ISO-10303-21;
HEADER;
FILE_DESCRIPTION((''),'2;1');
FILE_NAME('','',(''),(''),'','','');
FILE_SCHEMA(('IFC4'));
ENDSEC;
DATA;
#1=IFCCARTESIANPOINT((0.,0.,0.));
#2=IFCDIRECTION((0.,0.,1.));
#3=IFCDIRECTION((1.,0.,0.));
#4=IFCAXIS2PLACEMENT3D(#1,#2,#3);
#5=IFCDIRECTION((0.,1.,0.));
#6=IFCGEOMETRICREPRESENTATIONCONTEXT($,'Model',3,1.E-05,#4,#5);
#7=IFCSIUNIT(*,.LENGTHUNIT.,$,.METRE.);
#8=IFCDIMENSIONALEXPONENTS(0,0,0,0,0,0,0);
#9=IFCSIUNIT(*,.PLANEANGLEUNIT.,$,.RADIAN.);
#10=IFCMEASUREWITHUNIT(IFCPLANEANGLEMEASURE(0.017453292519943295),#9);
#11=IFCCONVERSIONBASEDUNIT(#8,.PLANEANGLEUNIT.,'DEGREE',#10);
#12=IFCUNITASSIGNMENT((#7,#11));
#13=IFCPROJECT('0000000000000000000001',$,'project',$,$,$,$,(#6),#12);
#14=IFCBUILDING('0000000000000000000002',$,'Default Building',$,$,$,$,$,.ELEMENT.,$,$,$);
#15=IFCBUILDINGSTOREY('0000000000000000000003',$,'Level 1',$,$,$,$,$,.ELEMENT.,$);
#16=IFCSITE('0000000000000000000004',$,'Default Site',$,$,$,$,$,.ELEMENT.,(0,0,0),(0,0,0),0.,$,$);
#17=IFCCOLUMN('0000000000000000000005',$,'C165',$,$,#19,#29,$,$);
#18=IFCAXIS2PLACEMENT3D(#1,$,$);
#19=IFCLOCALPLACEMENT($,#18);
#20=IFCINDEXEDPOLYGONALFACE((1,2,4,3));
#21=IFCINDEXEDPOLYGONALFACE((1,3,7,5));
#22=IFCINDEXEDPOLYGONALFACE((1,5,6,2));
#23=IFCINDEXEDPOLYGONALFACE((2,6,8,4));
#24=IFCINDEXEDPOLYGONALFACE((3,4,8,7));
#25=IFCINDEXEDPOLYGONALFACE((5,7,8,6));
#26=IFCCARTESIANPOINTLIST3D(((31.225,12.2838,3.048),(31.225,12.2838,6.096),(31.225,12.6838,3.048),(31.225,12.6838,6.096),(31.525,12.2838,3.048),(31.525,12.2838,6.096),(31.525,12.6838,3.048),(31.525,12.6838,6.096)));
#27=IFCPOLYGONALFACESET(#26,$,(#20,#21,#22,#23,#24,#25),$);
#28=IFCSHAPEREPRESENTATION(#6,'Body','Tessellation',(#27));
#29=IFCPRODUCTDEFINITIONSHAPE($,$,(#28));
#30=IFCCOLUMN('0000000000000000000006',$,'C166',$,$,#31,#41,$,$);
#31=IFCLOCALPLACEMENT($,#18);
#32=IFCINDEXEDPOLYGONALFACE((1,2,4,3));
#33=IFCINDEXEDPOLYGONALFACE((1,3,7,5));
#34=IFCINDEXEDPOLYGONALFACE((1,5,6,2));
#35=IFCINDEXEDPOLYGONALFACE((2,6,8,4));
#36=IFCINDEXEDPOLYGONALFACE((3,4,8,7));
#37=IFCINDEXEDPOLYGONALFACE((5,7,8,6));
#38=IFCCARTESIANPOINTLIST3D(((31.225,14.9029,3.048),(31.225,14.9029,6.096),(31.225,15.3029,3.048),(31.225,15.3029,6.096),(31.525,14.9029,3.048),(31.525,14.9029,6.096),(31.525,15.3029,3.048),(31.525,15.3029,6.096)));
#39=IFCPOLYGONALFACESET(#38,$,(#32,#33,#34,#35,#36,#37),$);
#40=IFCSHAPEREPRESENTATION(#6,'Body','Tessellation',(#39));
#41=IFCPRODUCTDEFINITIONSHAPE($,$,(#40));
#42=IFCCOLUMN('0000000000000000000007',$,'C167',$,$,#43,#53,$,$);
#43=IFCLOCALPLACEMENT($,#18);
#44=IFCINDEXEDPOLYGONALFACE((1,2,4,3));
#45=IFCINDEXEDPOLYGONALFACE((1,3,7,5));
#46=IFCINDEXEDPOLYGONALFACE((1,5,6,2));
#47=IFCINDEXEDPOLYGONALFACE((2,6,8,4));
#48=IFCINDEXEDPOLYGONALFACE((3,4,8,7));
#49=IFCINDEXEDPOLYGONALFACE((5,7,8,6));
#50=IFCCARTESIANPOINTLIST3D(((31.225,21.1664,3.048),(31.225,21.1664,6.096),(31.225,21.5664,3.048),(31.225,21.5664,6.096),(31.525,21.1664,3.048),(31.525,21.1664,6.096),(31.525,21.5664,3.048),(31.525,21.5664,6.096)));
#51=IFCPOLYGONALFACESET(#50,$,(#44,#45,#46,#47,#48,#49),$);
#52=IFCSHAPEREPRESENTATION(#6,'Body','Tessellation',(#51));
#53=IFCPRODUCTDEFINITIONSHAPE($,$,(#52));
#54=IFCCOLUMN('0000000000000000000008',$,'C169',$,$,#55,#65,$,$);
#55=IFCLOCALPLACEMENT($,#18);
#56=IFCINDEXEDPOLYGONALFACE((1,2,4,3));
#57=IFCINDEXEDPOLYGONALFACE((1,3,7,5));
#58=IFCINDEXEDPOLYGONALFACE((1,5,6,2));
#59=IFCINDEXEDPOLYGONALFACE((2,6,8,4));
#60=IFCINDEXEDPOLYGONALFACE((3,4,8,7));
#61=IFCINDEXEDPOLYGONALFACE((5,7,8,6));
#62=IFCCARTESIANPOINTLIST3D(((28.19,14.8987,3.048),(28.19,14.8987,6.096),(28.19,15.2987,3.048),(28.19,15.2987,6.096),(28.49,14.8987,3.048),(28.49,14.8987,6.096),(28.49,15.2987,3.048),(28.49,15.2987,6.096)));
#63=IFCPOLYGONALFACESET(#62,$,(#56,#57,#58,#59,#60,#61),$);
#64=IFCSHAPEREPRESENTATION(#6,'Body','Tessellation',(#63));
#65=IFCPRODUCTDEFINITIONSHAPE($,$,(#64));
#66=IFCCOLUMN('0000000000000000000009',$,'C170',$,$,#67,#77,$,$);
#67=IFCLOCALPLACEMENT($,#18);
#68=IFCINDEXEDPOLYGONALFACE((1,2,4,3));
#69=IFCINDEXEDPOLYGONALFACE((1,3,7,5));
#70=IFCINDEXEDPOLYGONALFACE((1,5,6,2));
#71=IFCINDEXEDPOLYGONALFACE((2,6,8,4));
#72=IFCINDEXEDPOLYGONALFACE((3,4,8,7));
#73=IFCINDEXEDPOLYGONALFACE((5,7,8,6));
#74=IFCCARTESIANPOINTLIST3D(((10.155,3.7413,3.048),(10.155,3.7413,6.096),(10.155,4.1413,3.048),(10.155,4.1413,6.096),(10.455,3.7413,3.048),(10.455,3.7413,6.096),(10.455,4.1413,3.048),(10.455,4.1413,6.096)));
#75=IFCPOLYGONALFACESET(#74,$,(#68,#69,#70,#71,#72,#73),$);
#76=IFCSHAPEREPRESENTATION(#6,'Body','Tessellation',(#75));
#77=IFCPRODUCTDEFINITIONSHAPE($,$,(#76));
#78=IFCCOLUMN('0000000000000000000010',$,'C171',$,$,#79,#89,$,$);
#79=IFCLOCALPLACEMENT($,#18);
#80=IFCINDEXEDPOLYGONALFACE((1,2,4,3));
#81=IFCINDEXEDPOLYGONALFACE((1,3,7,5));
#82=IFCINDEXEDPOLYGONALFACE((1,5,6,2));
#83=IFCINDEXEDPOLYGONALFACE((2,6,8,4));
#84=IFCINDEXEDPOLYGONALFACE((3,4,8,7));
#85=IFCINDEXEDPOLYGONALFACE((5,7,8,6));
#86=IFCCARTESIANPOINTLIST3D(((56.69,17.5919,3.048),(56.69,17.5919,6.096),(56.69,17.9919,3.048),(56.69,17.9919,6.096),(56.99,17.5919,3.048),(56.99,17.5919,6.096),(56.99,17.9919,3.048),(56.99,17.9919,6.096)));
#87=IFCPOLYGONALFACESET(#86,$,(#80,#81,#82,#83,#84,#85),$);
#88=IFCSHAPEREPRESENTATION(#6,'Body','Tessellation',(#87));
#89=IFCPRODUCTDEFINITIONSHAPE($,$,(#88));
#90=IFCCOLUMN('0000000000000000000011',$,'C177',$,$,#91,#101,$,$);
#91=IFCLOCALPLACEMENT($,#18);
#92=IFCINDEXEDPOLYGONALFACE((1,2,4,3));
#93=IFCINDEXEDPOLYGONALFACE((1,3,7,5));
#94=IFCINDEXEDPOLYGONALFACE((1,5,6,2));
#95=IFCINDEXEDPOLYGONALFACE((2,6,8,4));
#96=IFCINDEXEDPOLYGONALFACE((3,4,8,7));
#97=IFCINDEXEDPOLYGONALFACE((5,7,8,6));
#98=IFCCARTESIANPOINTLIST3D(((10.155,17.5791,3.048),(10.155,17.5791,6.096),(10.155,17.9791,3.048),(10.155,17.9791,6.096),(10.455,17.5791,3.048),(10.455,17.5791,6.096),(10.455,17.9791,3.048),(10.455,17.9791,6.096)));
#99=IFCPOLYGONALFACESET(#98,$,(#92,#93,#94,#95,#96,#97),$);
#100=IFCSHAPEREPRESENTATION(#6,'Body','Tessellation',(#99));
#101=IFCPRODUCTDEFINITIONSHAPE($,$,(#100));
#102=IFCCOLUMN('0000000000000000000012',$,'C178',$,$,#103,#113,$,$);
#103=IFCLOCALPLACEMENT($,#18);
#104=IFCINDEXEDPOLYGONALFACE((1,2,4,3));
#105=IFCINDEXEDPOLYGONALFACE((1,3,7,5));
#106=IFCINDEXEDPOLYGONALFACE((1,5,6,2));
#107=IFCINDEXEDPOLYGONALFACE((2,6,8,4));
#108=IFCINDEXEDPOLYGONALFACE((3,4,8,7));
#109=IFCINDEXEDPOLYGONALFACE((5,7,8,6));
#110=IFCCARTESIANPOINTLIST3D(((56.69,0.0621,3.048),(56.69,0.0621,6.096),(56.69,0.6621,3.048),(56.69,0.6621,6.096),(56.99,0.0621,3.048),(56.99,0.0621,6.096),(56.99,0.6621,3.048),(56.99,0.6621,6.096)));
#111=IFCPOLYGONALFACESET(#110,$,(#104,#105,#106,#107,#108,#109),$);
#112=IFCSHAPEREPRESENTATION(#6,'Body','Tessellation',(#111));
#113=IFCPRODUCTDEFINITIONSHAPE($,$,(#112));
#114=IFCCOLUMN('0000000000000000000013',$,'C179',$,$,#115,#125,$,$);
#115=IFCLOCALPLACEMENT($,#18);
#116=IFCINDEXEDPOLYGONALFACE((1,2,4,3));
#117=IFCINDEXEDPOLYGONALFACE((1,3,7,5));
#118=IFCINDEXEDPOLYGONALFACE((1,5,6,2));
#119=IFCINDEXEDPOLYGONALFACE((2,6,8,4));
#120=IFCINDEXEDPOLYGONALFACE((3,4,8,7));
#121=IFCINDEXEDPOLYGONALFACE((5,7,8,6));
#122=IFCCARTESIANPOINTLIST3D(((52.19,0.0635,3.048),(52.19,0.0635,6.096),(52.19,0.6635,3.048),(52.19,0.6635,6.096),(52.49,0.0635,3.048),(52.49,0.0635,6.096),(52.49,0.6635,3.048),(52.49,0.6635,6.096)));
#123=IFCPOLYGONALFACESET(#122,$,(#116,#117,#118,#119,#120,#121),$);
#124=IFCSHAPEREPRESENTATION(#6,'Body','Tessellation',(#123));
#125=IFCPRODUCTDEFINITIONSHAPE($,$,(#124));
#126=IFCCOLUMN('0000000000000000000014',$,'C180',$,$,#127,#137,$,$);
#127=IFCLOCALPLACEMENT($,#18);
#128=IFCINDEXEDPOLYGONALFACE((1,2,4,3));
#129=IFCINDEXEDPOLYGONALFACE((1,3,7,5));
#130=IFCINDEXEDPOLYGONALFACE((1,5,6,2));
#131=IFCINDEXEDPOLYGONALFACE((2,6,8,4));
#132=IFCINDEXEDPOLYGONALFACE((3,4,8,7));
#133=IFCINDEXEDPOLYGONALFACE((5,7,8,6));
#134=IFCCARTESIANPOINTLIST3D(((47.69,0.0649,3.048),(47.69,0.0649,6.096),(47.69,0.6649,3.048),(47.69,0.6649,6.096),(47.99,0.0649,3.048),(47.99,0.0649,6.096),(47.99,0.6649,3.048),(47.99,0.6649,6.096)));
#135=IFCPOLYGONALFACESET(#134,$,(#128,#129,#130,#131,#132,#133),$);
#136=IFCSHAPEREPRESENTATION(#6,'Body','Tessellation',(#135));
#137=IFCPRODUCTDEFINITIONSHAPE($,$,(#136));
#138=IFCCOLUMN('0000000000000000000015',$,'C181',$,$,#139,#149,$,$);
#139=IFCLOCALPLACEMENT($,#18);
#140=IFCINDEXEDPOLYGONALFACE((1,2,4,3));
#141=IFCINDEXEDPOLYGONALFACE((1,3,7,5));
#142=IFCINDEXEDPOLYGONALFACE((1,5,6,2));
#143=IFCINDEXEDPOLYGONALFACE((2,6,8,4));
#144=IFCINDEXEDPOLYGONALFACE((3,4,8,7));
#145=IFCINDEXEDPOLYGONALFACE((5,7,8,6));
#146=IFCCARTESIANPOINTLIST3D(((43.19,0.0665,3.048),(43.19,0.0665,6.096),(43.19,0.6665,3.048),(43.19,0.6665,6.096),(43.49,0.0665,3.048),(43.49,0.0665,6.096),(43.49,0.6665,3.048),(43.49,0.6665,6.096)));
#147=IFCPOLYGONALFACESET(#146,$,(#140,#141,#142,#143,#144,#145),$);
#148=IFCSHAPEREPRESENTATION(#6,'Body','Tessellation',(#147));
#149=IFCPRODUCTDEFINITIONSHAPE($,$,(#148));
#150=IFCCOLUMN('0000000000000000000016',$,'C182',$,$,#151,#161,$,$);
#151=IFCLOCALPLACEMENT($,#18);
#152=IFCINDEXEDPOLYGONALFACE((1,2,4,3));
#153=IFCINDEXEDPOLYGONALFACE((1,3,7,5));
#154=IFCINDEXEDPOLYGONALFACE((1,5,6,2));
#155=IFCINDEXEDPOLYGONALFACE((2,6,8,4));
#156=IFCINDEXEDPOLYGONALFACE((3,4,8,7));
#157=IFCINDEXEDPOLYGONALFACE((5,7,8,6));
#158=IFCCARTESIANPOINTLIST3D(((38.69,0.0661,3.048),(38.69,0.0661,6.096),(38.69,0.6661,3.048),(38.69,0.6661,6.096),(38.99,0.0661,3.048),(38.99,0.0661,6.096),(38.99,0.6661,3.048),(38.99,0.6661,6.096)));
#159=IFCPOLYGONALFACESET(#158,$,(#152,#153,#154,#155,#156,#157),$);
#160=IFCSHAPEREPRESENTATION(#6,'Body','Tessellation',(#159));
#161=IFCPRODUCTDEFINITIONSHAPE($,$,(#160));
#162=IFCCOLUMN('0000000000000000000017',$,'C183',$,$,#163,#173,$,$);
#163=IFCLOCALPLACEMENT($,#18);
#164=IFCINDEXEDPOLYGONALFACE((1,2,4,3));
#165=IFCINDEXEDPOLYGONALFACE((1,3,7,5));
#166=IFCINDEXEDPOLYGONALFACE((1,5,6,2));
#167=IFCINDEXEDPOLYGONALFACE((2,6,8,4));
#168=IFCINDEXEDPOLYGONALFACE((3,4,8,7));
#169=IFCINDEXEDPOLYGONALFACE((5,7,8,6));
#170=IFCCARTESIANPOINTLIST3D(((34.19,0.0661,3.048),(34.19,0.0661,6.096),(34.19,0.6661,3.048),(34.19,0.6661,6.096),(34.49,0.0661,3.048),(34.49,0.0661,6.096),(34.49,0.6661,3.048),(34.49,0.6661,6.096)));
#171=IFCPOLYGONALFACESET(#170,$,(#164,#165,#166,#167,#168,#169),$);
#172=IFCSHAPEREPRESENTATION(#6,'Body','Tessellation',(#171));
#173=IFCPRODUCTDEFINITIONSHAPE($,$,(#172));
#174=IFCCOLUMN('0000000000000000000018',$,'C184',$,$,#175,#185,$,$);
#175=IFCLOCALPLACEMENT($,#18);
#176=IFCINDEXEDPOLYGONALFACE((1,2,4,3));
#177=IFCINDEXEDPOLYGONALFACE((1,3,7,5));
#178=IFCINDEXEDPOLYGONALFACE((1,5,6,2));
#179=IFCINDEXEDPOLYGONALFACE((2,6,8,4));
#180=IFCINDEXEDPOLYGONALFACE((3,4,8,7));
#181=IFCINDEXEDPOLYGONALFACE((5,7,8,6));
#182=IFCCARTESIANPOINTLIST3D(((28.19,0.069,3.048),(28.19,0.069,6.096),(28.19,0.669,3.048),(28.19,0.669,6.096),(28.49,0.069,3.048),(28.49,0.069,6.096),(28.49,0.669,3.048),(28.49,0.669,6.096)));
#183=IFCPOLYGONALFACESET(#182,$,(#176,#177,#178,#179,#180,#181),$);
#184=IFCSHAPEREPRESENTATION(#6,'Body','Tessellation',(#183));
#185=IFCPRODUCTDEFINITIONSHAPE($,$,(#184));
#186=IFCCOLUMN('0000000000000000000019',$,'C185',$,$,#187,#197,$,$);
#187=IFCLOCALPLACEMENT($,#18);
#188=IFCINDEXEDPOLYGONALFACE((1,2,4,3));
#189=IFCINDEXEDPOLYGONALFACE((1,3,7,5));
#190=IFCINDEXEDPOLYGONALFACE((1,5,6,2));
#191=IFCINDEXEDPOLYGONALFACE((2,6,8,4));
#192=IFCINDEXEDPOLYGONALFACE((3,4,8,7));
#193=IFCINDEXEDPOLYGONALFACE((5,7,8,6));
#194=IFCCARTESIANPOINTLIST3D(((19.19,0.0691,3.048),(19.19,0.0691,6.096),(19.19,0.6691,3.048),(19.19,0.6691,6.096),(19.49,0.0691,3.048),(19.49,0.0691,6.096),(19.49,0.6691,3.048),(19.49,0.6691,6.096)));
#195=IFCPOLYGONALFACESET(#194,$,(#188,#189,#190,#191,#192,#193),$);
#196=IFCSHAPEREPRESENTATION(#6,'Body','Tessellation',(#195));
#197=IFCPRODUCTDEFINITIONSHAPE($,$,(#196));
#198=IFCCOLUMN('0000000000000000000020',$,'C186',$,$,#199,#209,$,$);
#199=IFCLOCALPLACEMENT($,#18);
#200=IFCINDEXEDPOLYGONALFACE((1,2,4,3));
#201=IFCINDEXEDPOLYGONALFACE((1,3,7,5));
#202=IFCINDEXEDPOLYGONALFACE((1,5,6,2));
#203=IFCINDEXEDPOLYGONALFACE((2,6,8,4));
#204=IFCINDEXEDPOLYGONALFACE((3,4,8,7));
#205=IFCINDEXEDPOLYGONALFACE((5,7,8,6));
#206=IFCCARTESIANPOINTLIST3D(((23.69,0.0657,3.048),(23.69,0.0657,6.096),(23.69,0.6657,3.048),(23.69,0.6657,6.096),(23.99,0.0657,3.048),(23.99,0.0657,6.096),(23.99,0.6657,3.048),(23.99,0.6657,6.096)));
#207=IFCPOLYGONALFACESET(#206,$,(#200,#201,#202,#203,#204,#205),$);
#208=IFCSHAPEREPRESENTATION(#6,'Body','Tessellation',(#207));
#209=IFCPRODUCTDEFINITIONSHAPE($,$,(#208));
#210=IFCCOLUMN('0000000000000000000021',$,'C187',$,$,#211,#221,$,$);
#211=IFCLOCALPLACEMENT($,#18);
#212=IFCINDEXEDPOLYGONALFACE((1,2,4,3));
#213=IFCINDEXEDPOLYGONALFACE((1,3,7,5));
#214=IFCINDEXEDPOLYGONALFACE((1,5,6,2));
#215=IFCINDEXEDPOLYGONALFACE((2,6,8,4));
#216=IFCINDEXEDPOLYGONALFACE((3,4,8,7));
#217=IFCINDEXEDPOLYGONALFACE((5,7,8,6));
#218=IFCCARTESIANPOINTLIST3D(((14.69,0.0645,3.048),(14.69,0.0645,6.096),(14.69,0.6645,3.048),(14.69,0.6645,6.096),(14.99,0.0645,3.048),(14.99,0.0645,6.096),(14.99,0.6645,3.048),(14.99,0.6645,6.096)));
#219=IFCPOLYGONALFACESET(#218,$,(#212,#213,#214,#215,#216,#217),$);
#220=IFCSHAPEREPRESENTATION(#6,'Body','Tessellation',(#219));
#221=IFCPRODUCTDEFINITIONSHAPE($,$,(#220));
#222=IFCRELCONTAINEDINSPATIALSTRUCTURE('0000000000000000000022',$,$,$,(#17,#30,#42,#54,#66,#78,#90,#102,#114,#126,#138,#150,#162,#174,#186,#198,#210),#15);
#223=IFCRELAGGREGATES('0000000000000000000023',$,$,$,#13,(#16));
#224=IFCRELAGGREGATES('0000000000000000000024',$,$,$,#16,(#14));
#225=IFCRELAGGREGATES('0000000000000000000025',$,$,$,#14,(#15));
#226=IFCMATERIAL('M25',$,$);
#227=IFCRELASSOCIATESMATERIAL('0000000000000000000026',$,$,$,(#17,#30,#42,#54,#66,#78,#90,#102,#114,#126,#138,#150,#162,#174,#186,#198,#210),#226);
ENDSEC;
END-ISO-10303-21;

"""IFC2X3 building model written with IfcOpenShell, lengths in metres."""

from ifc_helpers import new_model, entity, si_unit, converted_unit, direction, frame, frame_2d, origin_with_axes, place, context, project, spatial, rectangle, extrude, material, element, save


model = new_model("IFC2X3")

# Units and contexts
model_context = context("Model", 3, precision=1e-05, world=origin_with_axes(), true_north=direction((0.0, 1.0, 0.0)))
ifc_project = project(units=[si_unit("LENGTHUNIT", "METRE"), converted_unit("PLANEANGLEUNIT", "DEGREE", entity("IfcPlaneAngleMeasure", 0.017453292519943295), si_unit("PLANEANGLEUNIT", "RADIAN"), dimensions=[0, 0, 0, 0, 0, 0, 0])], contexts=[model_context])

# Site, building, storey
site = spatial("IfcSite", under=ifc_project, Name="Default Site", CompositionType="ELEMENT", RefLatitude=(0, 0, 0), RefLongitude=(0, 0, 0), RefElevation=0.0)
building = spatial("IfcBuilding", under=site, Name="Default Building", CompositionType="ELEMENT")
storey = spatial("IfcBuildingStorey", under=building, Name="Level 1", CompositionType="ELEMENT")

# Columns
ifc_material = material(Name="M25")
placement = place(None, origin_with_axes())
element("IfcColumn", 1, at=placement, inside=storey, material=ifc_material, Name="C165", context=model_context, shape_type="SweptSolid", body=[
    extrude(rectangle(XDim=0.3, YDim=0.4, at=frame_2d((0.0, 0.0), x_axis=(1.0, 0.0, 0.0))), frame((31.375, 12.4838, 3.048), z_axis=(0.0, 0.0, 1.0), x_axis=(1.0, 0.0, 0.0)), (0.0, 0.0, 1.0), 3.048),
])
element("IfcColumn", 2, at=placement, inside=storey, material=ifc_material, Name="C166", context=model_context, shape_type="SweptSolid", body=[
    extrude(rectangle(XDim=0.3, YDim=0.4, at=frame_2d((0.0, 0.0), x_axis=(1.0, 0.0, 0.0))), frame((31.375, 15.1029, 3.048), z_axis=(0.0, 0.0, 1.0), x_axis=(1.0, 0.0, 0.0)), (0.0, 0.0, 1.0), 3.048),
])
element("IfcColumn", 3, at=placement, inside=storey, material=ifc_material, Name="C167", context=model_context, shape_type="SweptSolid", body=[
    extrude(rectangle(XDim=0.3, YDim=0.4, at=frame_2d((0.0, 0.0), x_axis=(1.0, 0.0, 0.0))), frame((31.375, 21.3664, 3.048), z_axis=(0.0, 0.0, 1.0), x_axis=(1.0, 0.0, 0.0)), (0.0, 0.0, 1.0), 3.048),
])
element("IfcColumn", 4, at=placement, inside=storey, material=ifc_material, Name="C169", context=model_context, shape_type="SweptSolid", body=[
    extrude(rectangle(XDim=0.3, YDim=0.4, at=frame_2d((0.0, 0.0), x_axis=(1.0, 0.0, 0.0))), frame((28.34, 15.0987, 3.048), z_axis=(0.0, 0.0, 1.0), x_axis=(1.0, 0.0, 0.0)), (0.0, 0.0, 1.0), 3.048),
])
element("IfcColumn", 5, at=placement, inside=storey, material=ifc_material, Name="C170", context=model_context, shape_type="SweptSolid", body=[
    extrude(rectangle(XDim=0.3, YDim=0.4, at=frame_2d((0.0, 0.0), x_axis=(1.0, 0.0, 0.0))), frame((10.305, 3.9413, 3.048), z_axis=(0.0, 0.0, 1.0), x_axis=(1.0, 0.0, 0.0)), (0.0, 0.0, 1.0), 3.048),
])
element("IfcColumn", 6, at=placement, inside=storey, material=ifc_material, Name="C171", context=model_context, shape_type="SweptSolid", body=[
    extrude(rectangle(XDim=0.3, YDim=0.4, at=frame_2d((0.0, 0.0), x_axis=(1.0, 0.0, 0.0))), frame((56.84, 17.7919, 3.048), z_axis=(0.0, 0.0, 1.0), x_axis=(1.0, 0.0, 0.0)), (0.0, 0.0, 1.0), 3.048),
])
element("IfcColumn", 7, at=placement, inside=storey, material=ifc_material, Name="C177", context=model_context, shape_type="SweptSolid", body=[
    extrude(rectangle(XDim=0.3, YDim=0.4, at=frame_2d((0.0, 0.0), x_axis=(1.0, 0.0, 0.0))), frame((10.305, 17.7791, 3.048), z_axis=(0.0, 0.0, 1.0), x_axis=(1.0, 0.0, 0.0)), (0.0, 0.0, 1.0), 3.048),
])
element("IfcColumn", 8, at=placement, inside=storey, material=ifc_material, Name="C178", context=model_context, shape_type="SweptSolid", body=[
    extrude(rectangle(XDim=0.3, YDim=0.6, at=frame_2d((0.0, 0.0), x_axis=(1.0, 0.0, 0.0))), frame((56.84, 0.3621, 3.048), z_axis=(0.0, 0.0, 1.0), x_axis=(1.0, 0.0, 0.0)), (0.0, 0.0, 1.0), 3.048),
])
element("IfcColumn", 9, at=placement, inside=storey, material=ifc_material, Name="C179", context=model_context, shape_type="SweptSolid", body=[
    extrude(rectangle(XDim=0.3, YDim=0.6, at=frame_2d((0.0, 0.0), x_axis=(1.0, 0.0, 0.0))), frame((52.34, 0.3635, 3.048), z_axis=(0.0, 0.0, 1.0), x_axis=(1.0, 0.0, 0.0)), (0.0, 0.0, 1.0), 3.048),
])
element("IfcColumn", 10, at=placement, inside=storey, material=ifc_material, Name="C180", context=model_context, shape_type="SweptSolid", body=[
    extrude(rectangle(XDim=0.3, YDim=0.6, at=frame_2d((0.0, 0.0), x_axis=(1.0, 0.0, 0.0))), frame((47.84, 0.3649, 3.048), z_axis=(0.0, 0.0, 1.0), x_axis=(1.0, 0.0, 0.0)), (0.0, 0.0, 1.0), 3.048),
])
element("IfcColumn", 11, at=placement, inside=storey, material=ifc_material, Name="C181", context=model_context, shape_type="SweptSolid", body=[
    extrude(rectangle(XDim=0.3, YDim=0.6, at=frame_2d((0.0, 0.0), x_axis=(1.0, 0.0, 0.0))), frame((43.34, 0.3665, 3.048), z_axis=(0.0, 0.0, 1.0), x_axis=(1.0, 0.0, 0.0)), (0.0, 0.0, 1.0), 3.048),
])
element("IfcColumn", 12, at=placement, inside=storey, material=ifc_material, Name="C182", context=model_context, shape_type="SweptSolid", body=[
    extrude(rectangle(XDim=0.3, YDim=0.6, at=frame_2d((0.0, 0.0), x_axis=(1.0, 0.0, 0.0))), frame((38.84, 0.3661, 3.048), z_axis=(0.0, 0.0, 1.0), x_axis=(1.0, 0.0, 0.0)), (0.0, 0.0, 1.0), 3.048),
])
element("IfcColumn", 13, at=placement, inside=storey, material=ifc_material, Name="C183", context=model_context, shape_type="SweptSolid", body=[
    extrude(rectangle(XDim=0.3, YDim=0.6, at=frame_2d((0.0, 0.0), x_axis=(1.0, 0.0, 0.0))), frame((34.34, 0.3661, 3.048), z_axis=(0.0, 0.0, 1.0), x_axis=(1.0, 0.0, 0.0)), (0.0, 0.0, 1.0), 3.048),
])
element("IfcColumn", 14, at=placement, inside=storey, material=ifc_material, Name="C184", context=model_context, shape_type="SweptSolid", body=[
    extrude(rectangle(XDim=0.3, YDim=0.6, at=frame_2d((0.0, 0.0), x_axis=(1.0, 0.0, 0.0))), frame((28.34, 0.369, 3.048), z_axis=(0.0, 0.0, 1.0), x_axis=(1.0, 0.0, 0.0)), (0.0, 0.0, 1.0), 3.048),
])
element("IfcColumn", 15, at=placement, inside=storey, material=ifc_material, Name="C185", context=model_context, shape_type="SweptSolid", body=[
    extrude(rectangle(XDim=0.3, YDim=0.6, at=frame_2d((0.0, 0.0), x_axis=(1.0, 0.0, 0.0))), frame((19.34, 0.3691, 3.048), z_axis=(0.0, 0.0, 1.0), x_axis=(1.0, 0.0, 0.0)), (0.0, 0.0, 1.0), 3.048),
])
element("IfcColumn", 16, at=placement, inside=storey, material=ifc_material, Name="C186", context=model_context, shape_type="SweptSolid", body=[
    extrude(rectangle(XDim=0.3, YDim=0.6, at=frame_2d((0.0, 0.0), x_axis=(1.0, 0.0, 0.0))), frame((23.84, 0.3657, 3.048), z_axis=(0.0, 0.0, 1.0), x_axis=(1.0, 0.0, 0.0)), (0.0, 0.0, 1.0), 3.048),
])
element("IfcColumn", 17, at=placement, inside=storey, material=ifc_material, Name="C187", context=model_context, shape_type="SweptSolid", body=[
    extrude(rectangle(XDim=0.3, YDim=0.6, at=frame_2d((0.0, 0.0), x_axis=(1.0, 0.0, 0.0))), frame((14.84, 0.3645, 3.048), z_axis=(0.0, 0.0, 1.0), x_axis=(1.0, 0.0, 0.0)), (0.0, 0.0, 1.0), 3.048),
])

save(model, "model.ifc")
